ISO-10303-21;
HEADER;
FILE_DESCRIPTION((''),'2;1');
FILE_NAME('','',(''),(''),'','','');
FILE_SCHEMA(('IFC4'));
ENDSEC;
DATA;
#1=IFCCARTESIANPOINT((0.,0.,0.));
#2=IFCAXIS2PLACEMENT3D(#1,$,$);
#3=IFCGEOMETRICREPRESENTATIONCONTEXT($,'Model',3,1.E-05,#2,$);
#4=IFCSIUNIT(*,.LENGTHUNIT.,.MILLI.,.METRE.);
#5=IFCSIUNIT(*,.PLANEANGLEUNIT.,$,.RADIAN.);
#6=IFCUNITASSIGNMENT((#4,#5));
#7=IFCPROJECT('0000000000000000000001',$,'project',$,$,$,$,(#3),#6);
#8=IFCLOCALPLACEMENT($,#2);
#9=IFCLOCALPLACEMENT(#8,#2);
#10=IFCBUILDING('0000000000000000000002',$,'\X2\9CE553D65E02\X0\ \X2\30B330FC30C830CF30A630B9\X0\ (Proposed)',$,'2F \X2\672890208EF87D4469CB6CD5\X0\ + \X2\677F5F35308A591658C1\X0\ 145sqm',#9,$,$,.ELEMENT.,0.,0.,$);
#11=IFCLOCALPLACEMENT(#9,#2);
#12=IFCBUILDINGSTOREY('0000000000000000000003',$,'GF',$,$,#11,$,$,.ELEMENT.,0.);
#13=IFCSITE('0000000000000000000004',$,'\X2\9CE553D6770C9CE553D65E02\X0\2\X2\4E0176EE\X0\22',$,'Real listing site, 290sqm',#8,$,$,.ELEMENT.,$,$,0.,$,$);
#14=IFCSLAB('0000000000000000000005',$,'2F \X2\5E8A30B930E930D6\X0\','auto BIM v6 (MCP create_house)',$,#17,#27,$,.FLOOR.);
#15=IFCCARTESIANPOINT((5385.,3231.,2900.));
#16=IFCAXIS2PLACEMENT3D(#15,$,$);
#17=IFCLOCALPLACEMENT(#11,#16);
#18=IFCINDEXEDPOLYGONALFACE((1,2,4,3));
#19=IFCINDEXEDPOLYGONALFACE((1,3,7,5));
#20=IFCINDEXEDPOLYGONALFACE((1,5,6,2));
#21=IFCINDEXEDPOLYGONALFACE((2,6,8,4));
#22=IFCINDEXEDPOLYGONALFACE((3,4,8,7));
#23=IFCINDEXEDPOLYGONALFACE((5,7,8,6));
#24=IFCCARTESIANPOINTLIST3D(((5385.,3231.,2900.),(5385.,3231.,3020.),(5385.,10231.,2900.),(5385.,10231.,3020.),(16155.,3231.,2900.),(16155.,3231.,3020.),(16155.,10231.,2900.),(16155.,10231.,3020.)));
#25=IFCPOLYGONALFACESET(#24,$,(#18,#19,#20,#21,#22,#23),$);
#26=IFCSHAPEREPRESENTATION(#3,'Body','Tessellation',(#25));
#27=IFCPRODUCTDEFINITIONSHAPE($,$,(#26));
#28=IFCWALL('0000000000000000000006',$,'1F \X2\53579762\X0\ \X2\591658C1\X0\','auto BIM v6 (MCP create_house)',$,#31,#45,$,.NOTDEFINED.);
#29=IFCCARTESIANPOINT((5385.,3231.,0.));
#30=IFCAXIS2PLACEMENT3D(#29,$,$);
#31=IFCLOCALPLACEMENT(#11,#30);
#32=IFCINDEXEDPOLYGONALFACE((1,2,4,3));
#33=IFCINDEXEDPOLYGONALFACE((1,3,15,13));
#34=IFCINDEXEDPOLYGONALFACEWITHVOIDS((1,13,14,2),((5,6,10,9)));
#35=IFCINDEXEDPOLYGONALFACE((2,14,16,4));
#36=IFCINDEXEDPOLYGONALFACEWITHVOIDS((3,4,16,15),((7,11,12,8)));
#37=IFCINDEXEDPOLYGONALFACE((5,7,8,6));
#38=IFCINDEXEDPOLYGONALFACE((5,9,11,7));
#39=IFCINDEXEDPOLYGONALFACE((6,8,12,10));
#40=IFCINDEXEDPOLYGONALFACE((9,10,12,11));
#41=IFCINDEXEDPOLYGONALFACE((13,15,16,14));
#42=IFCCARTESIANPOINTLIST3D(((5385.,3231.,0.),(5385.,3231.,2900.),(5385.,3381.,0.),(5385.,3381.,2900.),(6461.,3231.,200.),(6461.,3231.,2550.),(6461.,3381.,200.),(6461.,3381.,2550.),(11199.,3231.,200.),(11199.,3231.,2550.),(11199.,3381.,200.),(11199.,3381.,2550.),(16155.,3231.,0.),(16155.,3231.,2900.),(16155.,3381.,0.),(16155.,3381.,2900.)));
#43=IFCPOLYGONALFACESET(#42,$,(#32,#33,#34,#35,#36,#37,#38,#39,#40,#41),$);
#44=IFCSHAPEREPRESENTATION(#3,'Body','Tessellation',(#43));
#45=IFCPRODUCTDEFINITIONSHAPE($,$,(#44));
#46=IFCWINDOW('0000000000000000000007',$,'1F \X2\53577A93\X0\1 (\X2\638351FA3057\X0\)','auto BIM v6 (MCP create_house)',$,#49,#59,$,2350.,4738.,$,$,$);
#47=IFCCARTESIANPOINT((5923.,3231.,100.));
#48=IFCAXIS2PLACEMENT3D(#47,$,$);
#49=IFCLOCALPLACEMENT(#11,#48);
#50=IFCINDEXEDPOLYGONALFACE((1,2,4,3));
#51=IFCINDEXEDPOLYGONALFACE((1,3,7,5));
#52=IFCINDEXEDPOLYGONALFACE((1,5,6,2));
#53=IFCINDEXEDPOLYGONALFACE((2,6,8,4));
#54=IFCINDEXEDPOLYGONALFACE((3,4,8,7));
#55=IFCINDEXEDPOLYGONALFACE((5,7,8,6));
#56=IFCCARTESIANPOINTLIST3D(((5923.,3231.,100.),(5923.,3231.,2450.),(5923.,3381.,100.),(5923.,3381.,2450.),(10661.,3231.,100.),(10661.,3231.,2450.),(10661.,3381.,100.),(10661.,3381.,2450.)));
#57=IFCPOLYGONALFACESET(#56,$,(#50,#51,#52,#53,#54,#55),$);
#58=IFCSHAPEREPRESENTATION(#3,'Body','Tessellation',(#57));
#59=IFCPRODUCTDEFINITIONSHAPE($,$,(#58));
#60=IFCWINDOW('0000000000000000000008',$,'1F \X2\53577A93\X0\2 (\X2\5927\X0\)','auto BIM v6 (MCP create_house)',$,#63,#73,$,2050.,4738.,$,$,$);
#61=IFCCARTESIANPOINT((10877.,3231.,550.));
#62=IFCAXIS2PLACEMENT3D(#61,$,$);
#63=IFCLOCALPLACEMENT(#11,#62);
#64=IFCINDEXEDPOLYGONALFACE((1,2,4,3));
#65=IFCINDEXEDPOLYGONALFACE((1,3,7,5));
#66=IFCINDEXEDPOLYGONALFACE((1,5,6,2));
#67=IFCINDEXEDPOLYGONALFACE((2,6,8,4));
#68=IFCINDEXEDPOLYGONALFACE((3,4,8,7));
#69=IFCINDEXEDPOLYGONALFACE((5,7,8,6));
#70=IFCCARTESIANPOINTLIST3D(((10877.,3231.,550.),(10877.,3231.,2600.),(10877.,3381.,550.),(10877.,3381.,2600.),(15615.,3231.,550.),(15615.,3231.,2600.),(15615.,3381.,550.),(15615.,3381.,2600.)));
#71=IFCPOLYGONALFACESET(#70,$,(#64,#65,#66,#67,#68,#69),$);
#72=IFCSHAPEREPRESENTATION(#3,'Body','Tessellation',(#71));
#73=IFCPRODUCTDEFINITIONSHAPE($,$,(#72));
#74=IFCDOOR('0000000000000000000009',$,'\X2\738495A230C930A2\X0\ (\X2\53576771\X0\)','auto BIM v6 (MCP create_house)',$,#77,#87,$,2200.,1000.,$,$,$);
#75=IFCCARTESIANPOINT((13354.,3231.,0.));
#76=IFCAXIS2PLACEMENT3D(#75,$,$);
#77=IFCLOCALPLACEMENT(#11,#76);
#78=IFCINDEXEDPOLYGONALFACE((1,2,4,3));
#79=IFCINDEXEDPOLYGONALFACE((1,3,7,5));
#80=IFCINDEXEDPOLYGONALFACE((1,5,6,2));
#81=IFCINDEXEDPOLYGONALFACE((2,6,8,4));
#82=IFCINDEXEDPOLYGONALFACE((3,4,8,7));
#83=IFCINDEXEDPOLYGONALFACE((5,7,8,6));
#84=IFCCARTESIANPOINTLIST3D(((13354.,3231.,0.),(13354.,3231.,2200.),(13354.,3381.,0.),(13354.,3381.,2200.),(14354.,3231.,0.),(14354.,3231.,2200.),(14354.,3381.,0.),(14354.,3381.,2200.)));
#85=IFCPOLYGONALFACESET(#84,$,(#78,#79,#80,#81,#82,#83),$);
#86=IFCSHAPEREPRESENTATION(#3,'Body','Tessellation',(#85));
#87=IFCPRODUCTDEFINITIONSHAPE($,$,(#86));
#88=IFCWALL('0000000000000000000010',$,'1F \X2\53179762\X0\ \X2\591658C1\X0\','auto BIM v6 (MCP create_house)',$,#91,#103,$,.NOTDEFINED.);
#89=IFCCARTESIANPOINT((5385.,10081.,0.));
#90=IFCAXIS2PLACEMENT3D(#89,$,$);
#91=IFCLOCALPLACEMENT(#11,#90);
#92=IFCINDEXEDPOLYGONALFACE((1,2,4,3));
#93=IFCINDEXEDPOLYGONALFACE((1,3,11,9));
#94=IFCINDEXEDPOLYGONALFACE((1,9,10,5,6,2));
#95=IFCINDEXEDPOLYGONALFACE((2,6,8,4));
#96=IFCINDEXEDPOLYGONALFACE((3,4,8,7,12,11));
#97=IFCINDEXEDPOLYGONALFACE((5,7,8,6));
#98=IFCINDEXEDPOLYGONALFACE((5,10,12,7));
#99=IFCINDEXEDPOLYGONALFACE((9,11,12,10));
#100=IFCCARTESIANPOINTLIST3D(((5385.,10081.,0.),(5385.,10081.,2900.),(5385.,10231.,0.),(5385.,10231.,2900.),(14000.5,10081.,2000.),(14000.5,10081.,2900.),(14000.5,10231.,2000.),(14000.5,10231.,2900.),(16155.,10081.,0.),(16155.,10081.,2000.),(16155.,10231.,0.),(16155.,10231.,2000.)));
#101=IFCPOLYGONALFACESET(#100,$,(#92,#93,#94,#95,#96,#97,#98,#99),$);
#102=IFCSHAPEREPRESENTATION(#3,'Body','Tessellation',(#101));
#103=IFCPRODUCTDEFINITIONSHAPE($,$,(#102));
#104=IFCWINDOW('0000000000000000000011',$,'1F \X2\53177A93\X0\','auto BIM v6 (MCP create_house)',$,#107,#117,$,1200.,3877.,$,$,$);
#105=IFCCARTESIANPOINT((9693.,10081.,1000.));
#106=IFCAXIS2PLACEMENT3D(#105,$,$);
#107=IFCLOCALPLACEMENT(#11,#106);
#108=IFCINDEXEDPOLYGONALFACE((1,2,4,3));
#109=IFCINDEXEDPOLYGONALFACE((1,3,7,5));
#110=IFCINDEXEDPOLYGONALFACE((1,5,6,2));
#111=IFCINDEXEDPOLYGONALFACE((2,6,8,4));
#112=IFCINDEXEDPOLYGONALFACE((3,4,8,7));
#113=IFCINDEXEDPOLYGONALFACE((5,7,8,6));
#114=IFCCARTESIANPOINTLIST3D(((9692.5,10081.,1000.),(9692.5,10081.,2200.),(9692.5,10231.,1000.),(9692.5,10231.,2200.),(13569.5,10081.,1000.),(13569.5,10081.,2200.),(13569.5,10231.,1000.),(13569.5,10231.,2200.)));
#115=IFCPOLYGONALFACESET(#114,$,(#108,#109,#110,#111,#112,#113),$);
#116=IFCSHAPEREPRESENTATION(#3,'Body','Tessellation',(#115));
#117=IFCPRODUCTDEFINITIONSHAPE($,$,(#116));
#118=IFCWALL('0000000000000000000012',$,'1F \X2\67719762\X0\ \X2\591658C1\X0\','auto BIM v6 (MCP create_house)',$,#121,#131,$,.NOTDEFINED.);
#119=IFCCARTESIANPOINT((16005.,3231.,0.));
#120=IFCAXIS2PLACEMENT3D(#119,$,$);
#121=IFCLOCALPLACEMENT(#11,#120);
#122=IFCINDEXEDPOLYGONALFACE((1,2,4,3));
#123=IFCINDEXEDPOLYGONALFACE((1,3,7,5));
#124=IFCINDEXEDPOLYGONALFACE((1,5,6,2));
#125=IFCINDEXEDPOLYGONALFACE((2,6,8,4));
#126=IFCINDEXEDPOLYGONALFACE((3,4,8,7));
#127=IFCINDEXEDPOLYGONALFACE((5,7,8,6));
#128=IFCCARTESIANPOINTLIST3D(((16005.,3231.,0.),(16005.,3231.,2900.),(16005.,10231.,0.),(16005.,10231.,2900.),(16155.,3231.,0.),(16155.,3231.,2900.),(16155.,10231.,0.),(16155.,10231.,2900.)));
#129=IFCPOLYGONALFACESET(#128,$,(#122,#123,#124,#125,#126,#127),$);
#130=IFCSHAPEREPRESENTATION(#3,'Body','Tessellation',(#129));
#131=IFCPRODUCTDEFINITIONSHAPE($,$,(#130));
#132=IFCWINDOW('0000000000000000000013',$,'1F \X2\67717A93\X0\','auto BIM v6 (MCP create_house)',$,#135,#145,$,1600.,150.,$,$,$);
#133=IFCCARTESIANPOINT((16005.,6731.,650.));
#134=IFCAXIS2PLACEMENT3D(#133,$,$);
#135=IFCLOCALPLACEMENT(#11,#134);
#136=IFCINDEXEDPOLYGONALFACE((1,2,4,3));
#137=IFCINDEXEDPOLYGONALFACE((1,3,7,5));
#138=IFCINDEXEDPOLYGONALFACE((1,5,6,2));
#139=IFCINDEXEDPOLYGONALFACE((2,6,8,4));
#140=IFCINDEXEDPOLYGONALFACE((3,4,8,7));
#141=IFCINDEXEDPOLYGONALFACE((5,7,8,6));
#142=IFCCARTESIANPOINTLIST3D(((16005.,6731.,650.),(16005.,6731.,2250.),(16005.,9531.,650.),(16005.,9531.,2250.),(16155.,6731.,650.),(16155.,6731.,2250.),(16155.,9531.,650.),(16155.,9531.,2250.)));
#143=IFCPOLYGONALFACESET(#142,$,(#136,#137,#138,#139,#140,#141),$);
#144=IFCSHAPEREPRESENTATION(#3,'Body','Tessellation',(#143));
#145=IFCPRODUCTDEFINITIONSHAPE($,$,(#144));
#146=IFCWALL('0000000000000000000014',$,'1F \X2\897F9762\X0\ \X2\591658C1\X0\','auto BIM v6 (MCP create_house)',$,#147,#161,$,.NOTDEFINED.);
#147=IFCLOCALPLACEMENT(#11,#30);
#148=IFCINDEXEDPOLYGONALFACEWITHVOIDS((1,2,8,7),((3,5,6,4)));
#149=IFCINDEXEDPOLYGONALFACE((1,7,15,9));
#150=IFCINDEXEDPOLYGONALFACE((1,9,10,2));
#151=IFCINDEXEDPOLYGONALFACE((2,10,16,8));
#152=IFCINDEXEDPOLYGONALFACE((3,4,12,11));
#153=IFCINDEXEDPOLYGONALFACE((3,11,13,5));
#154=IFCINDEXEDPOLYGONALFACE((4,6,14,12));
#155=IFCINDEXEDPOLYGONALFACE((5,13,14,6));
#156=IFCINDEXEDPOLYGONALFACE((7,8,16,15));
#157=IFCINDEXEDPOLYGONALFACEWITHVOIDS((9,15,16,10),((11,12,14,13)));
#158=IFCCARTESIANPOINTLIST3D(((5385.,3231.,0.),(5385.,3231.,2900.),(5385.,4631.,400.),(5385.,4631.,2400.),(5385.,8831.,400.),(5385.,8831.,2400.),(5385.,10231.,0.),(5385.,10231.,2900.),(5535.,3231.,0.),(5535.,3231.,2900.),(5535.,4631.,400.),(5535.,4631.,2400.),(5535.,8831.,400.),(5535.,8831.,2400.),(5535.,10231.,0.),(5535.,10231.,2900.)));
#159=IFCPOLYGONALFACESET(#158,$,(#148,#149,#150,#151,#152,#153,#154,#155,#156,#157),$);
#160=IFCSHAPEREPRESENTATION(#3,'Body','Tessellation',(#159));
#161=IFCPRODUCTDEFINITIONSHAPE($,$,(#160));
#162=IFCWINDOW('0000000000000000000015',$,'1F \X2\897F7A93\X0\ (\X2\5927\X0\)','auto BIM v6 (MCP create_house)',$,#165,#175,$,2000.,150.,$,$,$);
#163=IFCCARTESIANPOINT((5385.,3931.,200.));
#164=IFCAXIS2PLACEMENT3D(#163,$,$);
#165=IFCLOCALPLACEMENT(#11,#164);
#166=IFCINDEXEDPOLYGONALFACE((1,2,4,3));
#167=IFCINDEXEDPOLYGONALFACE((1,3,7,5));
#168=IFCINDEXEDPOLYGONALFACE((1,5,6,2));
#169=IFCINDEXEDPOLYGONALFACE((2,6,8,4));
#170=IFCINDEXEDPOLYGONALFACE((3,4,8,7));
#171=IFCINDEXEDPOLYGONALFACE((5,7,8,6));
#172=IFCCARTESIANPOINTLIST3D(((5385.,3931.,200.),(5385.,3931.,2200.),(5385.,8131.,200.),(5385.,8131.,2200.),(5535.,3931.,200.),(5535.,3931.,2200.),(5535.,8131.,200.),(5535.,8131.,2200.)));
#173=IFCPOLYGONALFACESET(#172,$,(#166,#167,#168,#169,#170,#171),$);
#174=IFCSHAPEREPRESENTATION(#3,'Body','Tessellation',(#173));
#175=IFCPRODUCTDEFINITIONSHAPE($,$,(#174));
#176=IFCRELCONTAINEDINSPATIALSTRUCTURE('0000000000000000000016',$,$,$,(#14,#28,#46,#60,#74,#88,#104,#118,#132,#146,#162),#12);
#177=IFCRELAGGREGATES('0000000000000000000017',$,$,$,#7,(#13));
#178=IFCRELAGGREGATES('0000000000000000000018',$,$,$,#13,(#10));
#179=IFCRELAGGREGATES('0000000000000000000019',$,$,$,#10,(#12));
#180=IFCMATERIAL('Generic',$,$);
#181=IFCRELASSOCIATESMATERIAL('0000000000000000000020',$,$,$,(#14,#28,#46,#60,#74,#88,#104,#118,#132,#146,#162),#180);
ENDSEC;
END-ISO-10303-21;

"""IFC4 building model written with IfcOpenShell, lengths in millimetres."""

from ifc_helpers import new_model, si_unit, frame, frame_2d, origin, place, context, project, spatial, rectangle, extrude, material, element, fill, save


model = new_model("IFC4")

# Units and contexts
model_context = context("Model", 3, precision=1e-05, world=origin())
ifc_project = project(units=[si_unit("LENGTHUNIT", "METRE", prefix="MILLI"), si_unit("PLANEANGLEUNIT", "RADIAN")], contexts=[model_context])

# Site, building, storey
site_placement = place(None, origin())
site = spatial("IfcSite", under=ifc_project, at=site_placement, Name="鳥取県鳥取市2丁目22", ObjectType="Real listing site, 290sqm", CompositionType="ELEMENT", RefElevation=0.0)
building_placement = place(site_placement, origin())
building = spatial("IfcBuilding", under=site, at=building_placement, Name="鳥取市 コートハウス (Proposed)", ObjectType="2F 木造軸組構法 + 板張り外壁 145sqm", CompositionType="ELEMENT", ElevationOfRefHeight=0.0, ElevationOfTerrain=0.0)
storey_placement = place(building_placement, origin())
storey = spatial("IfcBuildingStorey", under=building, at=storey_placement, Name="GF", CompositionType="ELEMENT", Elevation=0.0)

# Slab
ifc_material = material(Name="Generic")
slab_1_placement = place(storey_placement, frame((5385.0, 3231.0, 2900.0)))
element("IfcSlab", 1, at=slab_1_placement, inside=storey, material=ifc_material, Name="2F 床スラブ", Description="auto BIM v6 (MCP create_house)", PredefinedType="FLOOR", context=model_context, shape_type="SweptSolid", body=[
    extrude(rectangle(XDim=10770.0, YDim=7000.0, at=frame_2d((5385.0, 3500.0))), frame((5385.0, 3231.0, 2900.0)), (0.0, 0.0, 1.0), 120.0),
])

# Wall, openings, windows, door
wall_1_placement = place(storey_placement, frame((5385.0, 3231.0, 0.0)))
wall_1 = element("IfcWall", 2, at=wall_1_placement, inside=storey, material=ifc_material, Name="1F 南面 外壁", Description="auto BIM v6 (MCP create_house)", PredefinedType="NOTDEFINED", context=model_context, shape_type="SweptSolid", body=[
    extrude(rectangle(XDim=10770.0, YDim=150.0, at=frame_2d((5385.0, 75.0))), frame((5385.0, 3231.0, 0.0)), (0.0, 0.0, 1.0), 2900.0),
])
opening_1_placement = place(storey_placement, frame((5923.0, 3231.0, 100.0)))
opening_1 = element("IfcOpeningElement", 3, at=opening_1_placement, cuts=wall_1, PredefinedType="NOTDEFINED", context=model_context, shape_type="SweptSolid", body=[
    extrude(rectangle(XDim=4738.0, YDim=150.0, at=frame_2d((2369.0, 75.0))), frame((5923.0, 3231.0, 100.0)), (0.0, 0.0, 1.0), 2350.0),
])
opening_2_placement = place(storey_placement, frame((10877.0, 3231.0, 550.0)))
opening_2 = element("IfcOpeningElement", 4, at=opening_2_placement, cuts=wall_1, PredefinedType="NOTDEFINED", context=model_context, shape_type="SweptSolid", body=[
    extrude(rectangle(XDim=4738.0, YDim=150.0, at=frame_2d((2369.0, 75.0))), frame((10877.0, 3231.0, 550.0)), (0.0, 0.0, 1.0), 2050.0),
])
opening_3_placement = place(storey_placement, frame((13354.0, 3231.0, 0.0)))
opening_3 = element("IfcOpeningElement", 5, at=opening_3_placement, cuts=wall_1, PredefinedType="NOTDEFINED", context=model_context, shape_type="SweptSolid", body=[
    extrude(rectangle(XDim=1000.0, YDim=150.0, at=frame_2d((500.0, 75.0))), frame((13354.0, 3231.0, 0.0)), (0.0, 0.0, 1.0), 2200.0),
])
window_1_placement = place(storey_placement, frame((5923.0, 3231.0, 100.0)))
window_1 = element("IfcWindow", 6, at=window_1_placement, inside=storey, material=ifc_material, Name="1F 南窓1 (掃出し)", Description="auto BIM v6 (MCP create_house)", OverallHeight=2350.0, OverallWidth=4738.0, context=model_context, shape_type="SweptSolid", body=[
    extrude(rectangle(XDim=4738.0, YDim=150.0, at=frame_2d((2369.0, 75.0))), frame((5923.0, 3231.0, 100.0)), (0.0, 0.0, 1.0), 2350.0),
])
fill(opening_1, window_1)
window_2_placement = place(storey_placement, frame((10877.0, 3231.0, 550.0)))
window_2 = element("IfcWindow", 7, at=window_2_placement, inside=storey, material=ifc_material, Name="1F 南窓2 (大)", Description="auto BIM v6 (MCP create_house)", OverallHeight=2050.0, OverallWidth=4738.0, context=model_context, shape_type="SweptSolid", body=[
    extrude(rectangle(XDim=4738.0, YDim=150.0, at=frame_2d((2369.0, 75.0))), frame((10877.0, 3231.0, 550.0)), (0.0, 0.0, 1.0), 2050.0),
])
fill(opening_2, window_2)
door_1_placement = place(storey_placement, frame((13354.0, 3231.0, 0.0)))
door_1 = element("IfcDoor", 8, at=door_1_placement, inside=storey, material=ifc_material, Name="玄関ドア (南東)", Description="auto BIM v6 (MCP create_house)", OverallHeight=2200.0, OverallWidth=1000.0, context=model_context, shape_type="SweptSolid", body=[
    extrude(rectangle(XDim=1000.0, YDim=150.0, at=frame_2d((500.0, 75.0))), frame((13354.0, 3231.0, 0.0)), (0.0, 0.0, 1.0), 2200.0),
])
fill(opening_3, door_1)

# Walls, openings, windows
wall_2_placement = place(storey_placement, frame((5385.0, 10081.0, 0.0)))
wall_2 = element("IfcWall", 9, at=wall_2_placement, inside=storey, material=ifc_material, Name="1F 北面 外壁", Description="auto BIM v6 (MCP create_house)", PredefinedType="NOTDEFINED", context=model_context, shape_type="SweptSolid", body=[
    extrude(rectangle(XDim=10770.0, YDim=150.0, at=frame_2d((5385.0, 75.0))), frame((5385.0, 10081.0, 0.0)), (0.0, 0.0, 1.0), 2900.0),
])
opening_4_placement = place(storey_placement, frame((9693.0, 10081.0, 1000.0)))
opening_4 = element("IfcOpeningElement", 10, at=opening_4_placement, cuts=wall_2, PredefinedType="NOTDEFINED", context=model_context, shape_type="SweptSolid", body=[
    extrude(rectangle(XDim=3877.0, YDim=150.0, at=frame_2d((1938.0, 75.0))), frame((9693.0, 10081.0, 1000.0)), (0.0, 0.0, 1.0), 1200.0),
])
window_3_placement = place(storey_placement, frame((9693.0, 10081.0, 1000.0)))
window_3 = element("IfcWindow", 11, at=window_3_placement, inside=storey, material=ifc_material, Name="1F 北窓", Description="auto BIM v6 (MCP create_house)", OverallHeight=1200.0, OverallWidth=3877.0, context=model_context, shape_type="SweptSolid", body=[
    extrude(rectangle(XDim=3877.0, YDim=150.0, at=frame_2d((1938.0, 75.0))), frame((9693.0, 10081.0, 1000.0)), (0.0, 0.0, 1.0), 1200.0),
])
fill(opening_4, window_3)
wall_3_placement = place(storey_placement, frame((16005.0, 3231.0, 0.0)))
wall_3 = element("IfcWall", 12, at=wall_3_placement, inside=storey, material=ifc_material, Name="1F 東面 外壁", Description="auto BIM v6 (MCP create_house)", PredefinedType="NOTDEFINED", context=model_context, shape_type="SweptSolid", body=[
    extrude(rectangle(XDim=150.0, YDim=7000.0, at=frame_2d((75.0, 3500.0))), frame((16005.0, 3231.0, 0.0)), (0.0, 0.0, 1.0), 2900.0),
])
opening_5_placement = place(storey_placement, frame((16005.0, 6731.0, 650.0)))
opening_5 = element("IfcOpeningElement", 13, at=opening_5_placement, cuts=wall_3, PredefinedType="NOTDEFINED", context=model_context, shape_type="SweptSolid", body=[
    extrude(rectangle(XDim=150.0, YDim=2800.0, at=frame_2d((75.0, 1400.0))), frame((16005.0, 6731.0, 650.0)), (0.0, 0.0, 1.0), 1600.0),
])
window_4_placement = place(storey_placement, frame((16005.0, 6731.0, 650.0)))
window_4 = element("IfcWindow", 14, at=window_4_placement, inside=storey, material=ifc_material, Name="1F 東窓", Description="auto BIM v6 (MCP create_house)", OverallHeight=1600.0, OverallWidth=150.0, context=model_context, shape_type="SweptSolid", body=[
    extrude(rectangle(XDim=150.0, YDim=2800.0, at=frame_2d((75.0, 1400.0))), frame((16005.0, 6731.0, 650.0)), (0.0, 0.0, 1.0), 1600.0),
])
fill(opening_5, window_4)
wall_4_placement = place(storey_placement, frame((5385.0, 3231.0, 0.0)))
wall_4 = element("IfcWall", 15, at=wall_4_placement, inside=storey, material=ifc_material, Name="1F 西面 外壁", Description="auto BIM v6 (MCP create_house)", PredefinedType="NOTDEFINED", context=model_context, shape_type="SweptSolid", body=[
    extrude(rectangle(XDim=150.0, YDim=7000.0, at=frame_2d((75.0, 3500.0))), frame((5385.0, 3231.0, 0.0)), (0.0, 0.0, 1.0), 2900.0),
])
opening_6_placement = place(storey_placement, frame((5385.0, 3931.0, 200.0)))
opening_6 = element("IfcOpeningElement", 16, at=opening_6_placement, cuts=wall_4, PredefinedType="NOTDEFINED", context=model_context, shape_type="SweptSolid", body=[
    extrude(rectangle(XDim=150.0, YDim=4200.0, at=frame_2d((75.0, 2100.0))), frame((5385.0, 3931.0, 200.0)), (0.0, 0.0, 1.0), 2000.0),
])
window_5_placement = place(storey_placement, frame((5385.0, 3931.0, 200.0)))
window_5 = element("IfcWindow", 17, at=window_5_placement, inside=storey, material=ifc_material, Name="1F 西窓 (大)", Description="auto BIM v6 (MCP create_house)", OverallHeight=2000.0, OverallWidth=150.0, context=model_context, shape_type="SweptSolid", body=[
    extrude(rectangle(XDim=150.0, YDim=4200.0, at=frame_2d((75.0, 2100.0))), frame((5385.0, 3931.0, 200.0)), (0.0, 0.0, 1.0), 2000.0),
])
fill(opening_6, window_5)

save(model, "model.ifc")
